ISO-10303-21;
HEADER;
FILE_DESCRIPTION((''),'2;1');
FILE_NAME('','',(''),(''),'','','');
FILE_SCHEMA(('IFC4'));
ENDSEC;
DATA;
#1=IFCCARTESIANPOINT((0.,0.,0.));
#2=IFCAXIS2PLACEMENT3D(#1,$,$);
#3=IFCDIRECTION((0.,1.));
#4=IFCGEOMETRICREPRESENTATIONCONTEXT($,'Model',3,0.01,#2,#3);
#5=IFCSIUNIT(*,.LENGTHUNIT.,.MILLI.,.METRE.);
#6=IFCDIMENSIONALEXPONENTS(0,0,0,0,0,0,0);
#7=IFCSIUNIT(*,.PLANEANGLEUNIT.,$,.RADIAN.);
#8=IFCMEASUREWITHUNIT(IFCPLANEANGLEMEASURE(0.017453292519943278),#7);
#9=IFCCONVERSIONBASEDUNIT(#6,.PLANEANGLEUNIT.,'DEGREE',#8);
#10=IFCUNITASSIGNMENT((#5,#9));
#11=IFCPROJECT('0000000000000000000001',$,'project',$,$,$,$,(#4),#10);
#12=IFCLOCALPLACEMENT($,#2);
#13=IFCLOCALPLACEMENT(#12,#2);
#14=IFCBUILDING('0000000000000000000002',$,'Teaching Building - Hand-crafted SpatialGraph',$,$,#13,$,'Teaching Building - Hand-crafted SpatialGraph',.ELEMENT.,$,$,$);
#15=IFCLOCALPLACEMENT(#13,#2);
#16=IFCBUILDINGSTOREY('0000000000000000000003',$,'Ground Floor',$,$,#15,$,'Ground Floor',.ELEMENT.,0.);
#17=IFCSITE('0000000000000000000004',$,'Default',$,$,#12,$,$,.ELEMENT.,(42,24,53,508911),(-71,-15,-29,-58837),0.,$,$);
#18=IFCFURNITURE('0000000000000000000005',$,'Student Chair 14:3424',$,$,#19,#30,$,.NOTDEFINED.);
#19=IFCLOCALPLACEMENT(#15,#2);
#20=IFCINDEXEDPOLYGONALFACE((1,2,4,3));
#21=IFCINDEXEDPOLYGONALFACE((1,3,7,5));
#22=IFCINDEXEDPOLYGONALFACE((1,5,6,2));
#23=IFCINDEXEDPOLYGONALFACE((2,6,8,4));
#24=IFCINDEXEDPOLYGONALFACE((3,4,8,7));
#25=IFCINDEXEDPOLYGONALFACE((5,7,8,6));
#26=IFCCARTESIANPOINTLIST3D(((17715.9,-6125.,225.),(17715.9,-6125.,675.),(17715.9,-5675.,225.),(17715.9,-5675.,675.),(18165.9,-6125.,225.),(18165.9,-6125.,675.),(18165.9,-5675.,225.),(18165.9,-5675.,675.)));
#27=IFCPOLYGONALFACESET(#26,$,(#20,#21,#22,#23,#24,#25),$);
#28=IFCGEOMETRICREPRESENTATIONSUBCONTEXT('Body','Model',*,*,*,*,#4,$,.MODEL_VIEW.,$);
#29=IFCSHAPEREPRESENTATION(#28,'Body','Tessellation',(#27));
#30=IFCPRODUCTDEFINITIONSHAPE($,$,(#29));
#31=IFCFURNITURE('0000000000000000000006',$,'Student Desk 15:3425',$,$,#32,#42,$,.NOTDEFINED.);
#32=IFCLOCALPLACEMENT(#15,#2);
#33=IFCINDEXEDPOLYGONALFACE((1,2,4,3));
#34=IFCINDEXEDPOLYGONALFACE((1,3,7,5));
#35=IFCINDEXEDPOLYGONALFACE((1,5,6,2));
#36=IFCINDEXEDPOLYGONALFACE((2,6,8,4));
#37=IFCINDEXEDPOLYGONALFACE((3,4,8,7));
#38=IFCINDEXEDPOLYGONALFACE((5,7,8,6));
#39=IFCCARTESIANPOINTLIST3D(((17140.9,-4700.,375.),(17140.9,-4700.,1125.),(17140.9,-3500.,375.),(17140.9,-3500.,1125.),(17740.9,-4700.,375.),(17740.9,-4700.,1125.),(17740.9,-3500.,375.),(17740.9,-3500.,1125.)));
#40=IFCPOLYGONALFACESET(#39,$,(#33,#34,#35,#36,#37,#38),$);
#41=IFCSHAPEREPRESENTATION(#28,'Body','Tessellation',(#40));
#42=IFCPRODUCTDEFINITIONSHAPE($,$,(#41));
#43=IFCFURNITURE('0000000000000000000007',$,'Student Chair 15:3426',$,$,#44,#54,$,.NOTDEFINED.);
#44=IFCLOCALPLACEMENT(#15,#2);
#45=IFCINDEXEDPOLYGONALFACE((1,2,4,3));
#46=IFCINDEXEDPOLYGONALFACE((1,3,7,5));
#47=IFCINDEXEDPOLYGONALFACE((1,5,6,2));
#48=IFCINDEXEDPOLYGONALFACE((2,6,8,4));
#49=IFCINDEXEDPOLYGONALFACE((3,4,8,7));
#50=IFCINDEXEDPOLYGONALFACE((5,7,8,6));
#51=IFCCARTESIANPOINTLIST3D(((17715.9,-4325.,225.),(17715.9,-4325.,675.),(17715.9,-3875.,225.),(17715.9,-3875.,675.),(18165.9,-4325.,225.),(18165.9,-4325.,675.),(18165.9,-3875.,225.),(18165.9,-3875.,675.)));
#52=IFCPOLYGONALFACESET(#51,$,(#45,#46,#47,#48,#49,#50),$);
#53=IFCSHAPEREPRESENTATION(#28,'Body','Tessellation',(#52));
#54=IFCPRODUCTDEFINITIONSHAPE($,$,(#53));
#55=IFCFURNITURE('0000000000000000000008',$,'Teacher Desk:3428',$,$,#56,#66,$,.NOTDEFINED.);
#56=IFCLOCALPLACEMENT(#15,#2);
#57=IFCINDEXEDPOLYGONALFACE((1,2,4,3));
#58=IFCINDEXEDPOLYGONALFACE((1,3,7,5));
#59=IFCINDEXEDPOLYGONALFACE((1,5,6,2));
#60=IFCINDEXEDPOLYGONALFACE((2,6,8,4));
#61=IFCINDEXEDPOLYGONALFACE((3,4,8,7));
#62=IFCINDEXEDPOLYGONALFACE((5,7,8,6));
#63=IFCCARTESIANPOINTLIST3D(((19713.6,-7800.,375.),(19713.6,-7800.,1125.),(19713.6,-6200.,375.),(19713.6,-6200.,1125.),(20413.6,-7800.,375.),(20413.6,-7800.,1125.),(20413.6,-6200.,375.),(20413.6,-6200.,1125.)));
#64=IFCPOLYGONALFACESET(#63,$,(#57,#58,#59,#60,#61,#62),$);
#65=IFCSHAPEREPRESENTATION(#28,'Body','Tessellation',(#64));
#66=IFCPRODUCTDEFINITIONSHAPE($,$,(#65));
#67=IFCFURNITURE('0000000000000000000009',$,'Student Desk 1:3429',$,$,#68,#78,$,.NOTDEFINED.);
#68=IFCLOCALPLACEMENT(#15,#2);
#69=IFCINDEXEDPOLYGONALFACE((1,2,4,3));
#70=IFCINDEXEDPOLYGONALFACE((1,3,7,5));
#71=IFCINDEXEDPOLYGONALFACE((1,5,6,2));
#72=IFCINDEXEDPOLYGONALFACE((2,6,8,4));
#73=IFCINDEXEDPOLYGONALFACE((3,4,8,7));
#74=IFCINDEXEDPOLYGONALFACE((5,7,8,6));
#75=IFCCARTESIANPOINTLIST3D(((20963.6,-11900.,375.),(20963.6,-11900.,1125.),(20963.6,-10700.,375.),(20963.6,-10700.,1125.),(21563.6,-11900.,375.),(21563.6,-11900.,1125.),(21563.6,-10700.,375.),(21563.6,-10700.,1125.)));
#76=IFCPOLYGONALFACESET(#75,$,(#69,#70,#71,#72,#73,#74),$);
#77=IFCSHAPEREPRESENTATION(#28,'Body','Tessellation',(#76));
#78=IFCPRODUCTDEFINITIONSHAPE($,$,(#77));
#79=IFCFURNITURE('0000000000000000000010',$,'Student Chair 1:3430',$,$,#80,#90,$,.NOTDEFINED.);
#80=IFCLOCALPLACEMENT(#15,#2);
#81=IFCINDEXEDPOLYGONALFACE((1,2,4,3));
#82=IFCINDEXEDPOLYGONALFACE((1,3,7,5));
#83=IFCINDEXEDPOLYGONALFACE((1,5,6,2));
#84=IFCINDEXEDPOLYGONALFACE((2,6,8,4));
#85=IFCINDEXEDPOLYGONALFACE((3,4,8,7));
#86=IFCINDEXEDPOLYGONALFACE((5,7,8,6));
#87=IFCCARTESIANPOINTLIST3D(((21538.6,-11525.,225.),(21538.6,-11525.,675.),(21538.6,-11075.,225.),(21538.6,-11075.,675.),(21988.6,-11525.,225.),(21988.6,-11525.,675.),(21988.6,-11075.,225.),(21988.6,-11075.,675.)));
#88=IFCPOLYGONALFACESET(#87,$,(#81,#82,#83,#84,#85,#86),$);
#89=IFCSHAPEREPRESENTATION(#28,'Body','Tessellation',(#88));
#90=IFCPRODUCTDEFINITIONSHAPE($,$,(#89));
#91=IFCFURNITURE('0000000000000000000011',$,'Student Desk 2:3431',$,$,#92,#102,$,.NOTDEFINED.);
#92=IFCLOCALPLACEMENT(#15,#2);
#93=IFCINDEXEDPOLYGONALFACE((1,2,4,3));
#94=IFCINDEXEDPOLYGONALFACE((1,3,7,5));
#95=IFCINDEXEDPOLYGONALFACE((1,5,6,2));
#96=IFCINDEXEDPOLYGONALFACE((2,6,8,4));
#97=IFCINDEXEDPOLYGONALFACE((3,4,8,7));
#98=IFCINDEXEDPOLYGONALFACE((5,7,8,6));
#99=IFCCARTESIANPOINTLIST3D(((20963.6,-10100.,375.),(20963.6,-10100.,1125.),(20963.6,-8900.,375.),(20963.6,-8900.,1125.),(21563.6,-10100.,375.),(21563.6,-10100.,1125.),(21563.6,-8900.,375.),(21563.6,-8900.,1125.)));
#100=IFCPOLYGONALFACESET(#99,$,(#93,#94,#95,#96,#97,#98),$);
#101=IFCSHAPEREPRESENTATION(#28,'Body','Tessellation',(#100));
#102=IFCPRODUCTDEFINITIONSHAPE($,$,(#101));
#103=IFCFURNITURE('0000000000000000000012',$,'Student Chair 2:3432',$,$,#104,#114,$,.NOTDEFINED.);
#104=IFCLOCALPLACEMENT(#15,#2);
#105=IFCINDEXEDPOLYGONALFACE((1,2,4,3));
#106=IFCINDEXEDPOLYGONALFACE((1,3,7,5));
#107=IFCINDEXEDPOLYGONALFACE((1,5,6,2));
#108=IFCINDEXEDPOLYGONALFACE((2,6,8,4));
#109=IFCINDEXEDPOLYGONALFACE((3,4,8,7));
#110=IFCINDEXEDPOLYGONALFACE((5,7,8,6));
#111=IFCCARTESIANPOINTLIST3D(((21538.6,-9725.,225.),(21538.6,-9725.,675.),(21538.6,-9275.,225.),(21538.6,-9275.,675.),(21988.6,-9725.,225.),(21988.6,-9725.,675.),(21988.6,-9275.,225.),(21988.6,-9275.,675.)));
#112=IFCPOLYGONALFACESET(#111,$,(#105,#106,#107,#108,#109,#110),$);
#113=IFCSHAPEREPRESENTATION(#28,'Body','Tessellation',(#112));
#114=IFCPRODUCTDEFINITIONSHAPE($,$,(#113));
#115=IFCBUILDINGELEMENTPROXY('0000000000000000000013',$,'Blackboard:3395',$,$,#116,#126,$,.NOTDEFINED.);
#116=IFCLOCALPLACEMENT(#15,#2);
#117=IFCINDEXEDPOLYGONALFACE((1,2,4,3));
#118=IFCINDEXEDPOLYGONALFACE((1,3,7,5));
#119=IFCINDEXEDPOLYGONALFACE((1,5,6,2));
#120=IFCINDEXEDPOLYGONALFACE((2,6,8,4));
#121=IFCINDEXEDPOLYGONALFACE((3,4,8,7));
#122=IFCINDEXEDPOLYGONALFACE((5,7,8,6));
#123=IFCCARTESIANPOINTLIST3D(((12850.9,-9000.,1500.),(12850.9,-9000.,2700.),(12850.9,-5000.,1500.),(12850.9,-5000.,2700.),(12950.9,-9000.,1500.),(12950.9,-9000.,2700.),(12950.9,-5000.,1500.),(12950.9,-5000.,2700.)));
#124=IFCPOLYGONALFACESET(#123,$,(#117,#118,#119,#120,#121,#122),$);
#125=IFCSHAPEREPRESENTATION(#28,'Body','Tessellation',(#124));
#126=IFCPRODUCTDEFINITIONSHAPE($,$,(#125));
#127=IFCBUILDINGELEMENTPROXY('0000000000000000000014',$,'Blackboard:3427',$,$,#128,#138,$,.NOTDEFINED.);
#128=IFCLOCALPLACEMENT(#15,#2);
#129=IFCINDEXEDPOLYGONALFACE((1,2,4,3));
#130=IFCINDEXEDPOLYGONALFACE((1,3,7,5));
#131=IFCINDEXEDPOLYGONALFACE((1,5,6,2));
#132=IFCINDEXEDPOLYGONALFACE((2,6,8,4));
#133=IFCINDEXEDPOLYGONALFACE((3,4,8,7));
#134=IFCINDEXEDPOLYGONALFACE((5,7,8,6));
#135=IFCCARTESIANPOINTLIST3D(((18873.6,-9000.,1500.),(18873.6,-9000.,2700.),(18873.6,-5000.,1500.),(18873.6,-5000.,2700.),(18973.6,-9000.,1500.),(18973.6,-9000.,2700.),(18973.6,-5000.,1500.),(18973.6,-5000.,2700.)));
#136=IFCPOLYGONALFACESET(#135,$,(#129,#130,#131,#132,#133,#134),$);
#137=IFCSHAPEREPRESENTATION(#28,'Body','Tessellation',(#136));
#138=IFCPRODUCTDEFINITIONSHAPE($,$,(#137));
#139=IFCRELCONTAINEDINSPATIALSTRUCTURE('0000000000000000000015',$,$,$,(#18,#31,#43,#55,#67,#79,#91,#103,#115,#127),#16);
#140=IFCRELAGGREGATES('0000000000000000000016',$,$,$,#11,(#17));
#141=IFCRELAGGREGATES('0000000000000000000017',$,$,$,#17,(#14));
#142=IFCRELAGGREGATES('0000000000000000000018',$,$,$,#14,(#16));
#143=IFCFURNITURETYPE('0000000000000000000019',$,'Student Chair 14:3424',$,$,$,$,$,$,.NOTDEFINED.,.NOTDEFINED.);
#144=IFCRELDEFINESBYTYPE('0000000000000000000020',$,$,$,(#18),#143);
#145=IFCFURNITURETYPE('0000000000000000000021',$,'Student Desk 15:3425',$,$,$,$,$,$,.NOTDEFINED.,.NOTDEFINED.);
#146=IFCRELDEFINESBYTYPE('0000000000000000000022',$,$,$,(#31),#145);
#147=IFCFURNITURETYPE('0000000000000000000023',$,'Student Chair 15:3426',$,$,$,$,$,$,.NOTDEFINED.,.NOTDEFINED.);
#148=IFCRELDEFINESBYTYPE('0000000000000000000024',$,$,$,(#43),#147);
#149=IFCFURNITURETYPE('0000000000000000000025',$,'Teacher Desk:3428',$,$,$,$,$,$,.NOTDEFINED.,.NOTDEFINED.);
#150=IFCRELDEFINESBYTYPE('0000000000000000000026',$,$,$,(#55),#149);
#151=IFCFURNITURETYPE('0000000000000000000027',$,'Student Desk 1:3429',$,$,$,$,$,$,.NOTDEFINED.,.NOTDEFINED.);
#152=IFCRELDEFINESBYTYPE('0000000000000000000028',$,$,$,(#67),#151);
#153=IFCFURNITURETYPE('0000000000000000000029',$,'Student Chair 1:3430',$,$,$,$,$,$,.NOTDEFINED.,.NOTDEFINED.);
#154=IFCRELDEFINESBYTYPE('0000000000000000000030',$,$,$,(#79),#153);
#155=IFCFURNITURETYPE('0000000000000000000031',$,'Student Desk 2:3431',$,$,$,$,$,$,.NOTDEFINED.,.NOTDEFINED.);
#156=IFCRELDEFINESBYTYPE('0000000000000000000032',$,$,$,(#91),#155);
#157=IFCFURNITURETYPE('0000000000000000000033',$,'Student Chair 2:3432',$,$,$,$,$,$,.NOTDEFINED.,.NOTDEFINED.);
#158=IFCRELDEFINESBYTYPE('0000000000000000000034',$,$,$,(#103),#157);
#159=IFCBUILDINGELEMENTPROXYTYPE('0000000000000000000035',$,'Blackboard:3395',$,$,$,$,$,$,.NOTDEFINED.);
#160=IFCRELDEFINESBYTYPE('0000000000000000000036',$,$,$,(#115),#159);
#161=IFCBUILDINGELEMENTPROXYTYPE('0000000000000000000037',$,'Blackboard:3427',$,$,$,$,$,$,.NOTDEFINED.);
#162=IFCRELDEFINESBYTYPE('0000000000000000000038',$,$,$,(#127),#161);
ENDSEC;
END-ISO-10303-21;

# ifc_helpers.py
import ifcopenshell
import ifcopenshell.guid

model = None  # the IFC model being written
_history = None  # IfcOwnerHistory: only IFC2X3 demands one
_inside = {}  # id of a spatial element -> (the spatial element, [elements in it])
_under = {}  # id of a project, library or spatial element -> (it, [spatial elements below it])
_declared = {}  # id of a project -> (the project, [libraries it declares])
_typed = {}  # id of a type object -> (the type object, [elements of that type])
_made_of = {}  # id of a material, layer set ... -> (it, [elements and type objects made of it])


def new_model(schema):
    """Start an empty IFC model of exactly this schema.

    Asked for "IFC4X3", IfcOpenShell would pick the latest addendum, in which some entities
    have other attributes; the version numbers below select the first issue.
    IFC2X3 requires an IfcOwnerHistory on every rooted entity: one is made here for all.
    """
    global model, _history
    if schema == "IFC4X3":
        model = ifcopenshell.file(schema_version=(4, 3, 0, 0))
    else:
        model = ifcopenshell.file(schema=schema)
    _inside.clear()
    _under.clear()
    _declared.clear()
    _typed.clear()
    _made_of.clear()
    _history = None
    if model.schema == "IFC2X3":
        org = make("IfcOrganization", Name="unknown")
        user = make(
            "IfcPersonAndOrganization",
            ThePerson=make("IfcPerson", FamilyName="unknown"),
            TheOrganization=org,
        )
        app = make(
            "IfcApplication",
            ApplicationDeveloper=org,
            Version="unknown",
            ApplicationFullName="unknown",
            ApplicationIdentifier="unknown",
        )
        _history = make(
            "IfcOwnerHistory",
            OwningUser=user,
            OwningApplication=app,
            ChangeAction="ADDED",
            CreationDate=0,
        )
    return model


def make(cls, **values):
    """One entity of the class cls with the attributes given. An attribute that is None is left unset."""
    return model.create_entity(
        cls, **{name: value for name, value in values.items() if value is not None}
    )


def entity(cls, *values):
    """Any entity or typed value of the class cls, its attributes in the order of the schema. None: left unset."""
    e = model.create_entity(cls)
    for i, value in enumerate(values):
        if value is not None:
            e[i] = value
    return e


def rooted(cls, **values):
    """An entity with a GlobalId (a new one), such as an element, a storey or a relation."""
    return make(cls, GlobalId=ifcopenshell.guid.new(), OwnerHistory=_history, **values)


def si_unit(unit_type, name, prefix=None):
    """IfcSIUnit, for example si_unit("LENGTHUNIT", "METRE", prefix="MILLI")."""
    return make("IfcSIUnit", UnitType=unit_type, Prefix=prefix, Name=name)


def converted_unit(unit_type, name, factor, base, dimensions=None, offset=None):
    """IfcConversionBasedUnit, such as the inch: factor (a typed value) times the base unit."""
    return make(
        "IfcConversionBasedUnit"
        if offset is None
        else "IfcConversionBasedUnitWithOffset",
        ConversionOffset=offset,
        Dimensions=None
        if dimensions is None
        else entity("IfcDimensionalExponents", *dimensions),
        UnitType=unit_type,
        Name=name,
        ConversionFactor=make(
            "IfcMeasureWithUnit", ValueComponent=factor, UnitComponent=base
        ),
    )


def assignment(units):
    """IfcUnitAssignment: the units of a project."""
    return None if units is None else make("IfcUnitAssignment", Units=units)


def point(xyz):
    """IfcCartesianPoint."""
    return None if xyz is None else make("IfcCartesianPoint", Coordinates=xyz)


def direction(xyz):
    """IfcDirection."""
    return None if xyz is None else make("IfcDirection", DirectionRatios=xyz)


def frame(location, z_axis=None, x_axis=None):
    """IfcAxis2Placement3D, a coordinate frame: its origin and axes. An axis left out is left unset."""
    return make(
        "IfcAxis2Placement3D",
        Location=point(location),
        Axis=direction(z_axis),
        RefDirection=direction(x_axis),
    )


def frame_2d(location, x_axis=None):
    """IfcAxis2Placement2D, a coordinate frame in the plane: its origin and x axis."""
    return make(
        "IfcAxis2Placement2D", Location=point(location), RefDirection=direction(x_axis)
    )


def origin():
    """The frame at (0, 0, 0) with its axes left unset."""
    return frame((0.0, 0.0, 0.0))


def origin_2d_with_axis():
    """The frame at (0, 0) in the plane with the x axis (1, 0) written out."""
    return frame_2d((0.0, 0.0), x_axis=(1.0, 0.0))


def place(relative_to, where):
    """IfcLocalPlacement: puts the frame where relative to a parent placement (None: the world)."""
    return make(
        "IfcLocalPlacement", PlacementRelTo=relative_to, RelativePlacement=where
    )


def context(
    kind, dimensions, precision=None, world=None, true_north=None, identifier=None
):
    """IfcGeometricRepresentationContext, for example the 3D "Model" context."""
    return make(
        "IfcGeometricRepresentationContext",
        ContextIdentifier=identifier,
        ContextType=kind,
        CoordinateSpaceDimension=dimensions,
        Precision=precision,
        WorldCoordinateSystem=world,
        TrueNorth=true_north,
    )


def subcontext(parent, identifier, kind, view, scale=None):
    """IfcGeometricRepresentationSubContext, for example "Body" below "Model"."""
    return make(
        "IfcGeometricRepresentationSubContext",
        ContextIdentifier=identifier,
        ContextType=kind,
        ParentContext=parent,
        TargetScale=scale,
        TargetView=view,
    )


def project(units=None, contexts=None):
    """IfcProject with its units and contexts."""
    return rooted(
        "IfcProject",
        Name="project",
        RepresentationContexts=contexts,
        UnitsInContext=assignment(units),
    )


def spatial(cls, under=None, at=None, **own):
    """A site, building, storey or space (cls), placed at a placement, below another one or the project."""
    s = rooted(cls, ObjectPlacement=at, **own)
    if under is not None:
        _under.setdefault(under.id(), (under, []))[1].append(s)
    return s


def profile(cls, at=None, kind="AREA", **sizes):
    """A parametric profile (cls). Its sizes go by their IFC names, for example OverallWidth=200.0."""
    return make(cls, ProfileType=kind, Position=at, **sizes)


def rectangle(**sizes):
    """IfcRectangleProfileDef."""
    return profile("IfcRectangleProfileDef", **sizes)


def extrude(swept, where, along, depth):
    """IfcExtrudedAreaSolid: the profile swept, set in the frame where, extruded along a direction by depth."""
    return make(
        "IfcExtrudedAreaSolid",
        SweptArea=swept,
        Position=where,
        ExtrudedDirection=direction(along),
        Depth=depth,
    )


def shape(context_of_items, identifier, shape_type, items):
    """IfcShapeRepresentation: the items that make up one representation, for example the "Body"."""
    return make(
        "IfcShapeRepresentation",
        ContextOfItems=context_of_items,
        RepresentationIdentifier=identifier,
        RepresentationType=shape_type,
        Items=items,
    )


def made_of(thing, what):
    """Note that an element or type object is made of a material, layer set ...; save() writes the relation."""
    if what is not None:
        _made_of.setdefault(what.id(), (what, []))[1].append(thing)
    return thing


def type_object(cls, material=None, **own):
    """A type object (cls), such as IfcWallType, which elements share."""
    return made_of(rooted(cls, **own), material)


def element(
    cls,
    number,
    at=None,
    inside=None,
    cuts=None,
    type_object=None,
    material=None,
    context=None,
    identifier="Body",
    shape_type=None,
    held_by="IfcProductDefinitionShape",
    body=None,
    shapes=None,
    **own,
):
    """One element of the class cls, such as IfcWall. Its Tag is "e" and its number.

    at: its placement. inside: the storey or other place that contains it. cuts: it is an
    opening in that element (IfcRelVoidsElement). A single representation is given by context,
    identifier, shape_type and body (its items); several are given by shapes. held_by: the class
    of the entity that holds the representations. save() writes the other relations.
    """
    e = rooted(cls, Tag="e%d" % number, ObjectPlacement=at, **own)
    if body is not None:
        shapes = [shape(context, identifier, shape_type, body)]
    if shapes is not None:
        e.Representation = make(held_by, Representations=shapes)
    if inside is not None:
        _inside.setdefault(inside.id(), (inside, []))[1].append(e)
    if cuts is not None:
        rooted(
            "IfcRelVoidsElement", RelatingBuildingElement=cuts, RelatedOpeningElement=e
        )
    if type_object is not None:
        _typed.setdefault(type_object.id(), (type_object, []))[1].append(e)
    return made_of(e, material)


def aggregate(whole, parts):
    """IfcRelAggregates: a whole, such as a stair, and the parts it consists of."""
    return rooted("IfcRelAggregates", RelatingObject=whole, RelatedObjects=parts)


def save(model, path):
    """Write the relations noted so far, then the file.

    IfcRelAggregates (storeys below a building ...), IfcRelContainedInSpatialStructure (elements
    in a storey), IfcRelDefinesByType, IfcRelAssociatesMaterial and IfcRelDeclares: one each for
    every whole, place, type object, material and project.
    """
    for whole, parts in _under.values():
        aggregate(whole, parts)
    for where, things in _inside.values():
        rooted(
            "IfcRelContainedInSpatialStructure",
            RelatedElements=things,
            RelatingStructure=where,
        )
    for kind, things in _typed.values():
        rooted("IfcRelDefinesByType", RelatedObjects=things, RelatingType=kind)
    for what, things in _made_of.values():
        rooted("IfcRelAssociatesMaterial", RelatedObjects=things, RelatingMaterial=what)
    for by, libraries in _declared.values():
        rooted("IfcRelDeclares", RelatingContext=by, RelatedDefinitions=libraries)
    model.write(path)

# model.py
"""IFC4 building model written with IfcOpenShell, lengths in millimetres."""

from ifc_helpers import new_model, entity, si_unit, converted_unit, direction, frame, origin, origin_2d_with_axis, place, context, subcontext, project, spatial, rectangle, extrude, type_object, element, save


model = new_model("IFC4")

# Units and contexts
model_context = context("Model", 3, precision=0.01, world=origin(), true_north=direction((0.0, 1.0)))
body_context = subcontext(model_context, "Body", "Model", "MODEL_VIEW")
ifc_project = project(units=[si_unit("LENGTHUNIT", "METRE", prefix="MILLI"), converted_unit("PLANEANGLEUNIT", "DEGREE", entity("IfcPlaneAngleMeasure", 0.017453292519943278), si_unit("PLANEANGLEUNIT", "RADIAN"), dimensions=[0, 0, 0, 0, 0, 0, 0])], contexts=[model_context])

# Site, building, storey
site_placement = place(None, origin())
site = spatial("IfcSite", under=ifc_project, at=site_placement, Name="Default", CompositionType="ELEMENT", RefLatitude=(42, 24, 53, 508911), RefLongitude=(-71, -15, -29, -58837), RefElevation=0.0)
building_placement = place(site_placement, origin())
building = spatial("IfcBuilding", under=site, at=building_placement, Name="Teaching Building - Hand-crafted SpatialGraph", LongName="Teaching Building - Hand-crafted SpatialGraph", CompositionType="ELEMENT")
storey_placement = place(building_placement, origin())
storey = spatial("IfcBuildingStorey", under=building, at=storey_placement, Name="Ground Floor", LongName="Ground Floor", CompositionType="ELEMENT", Elevation=0.0)

# Furniture
furniture_type_1 = type_object("IfcFurnitureType", Name="Student Chair 14:3424", PredefinedType="NOTDEFINED")
furniture_1_placement = place(storey_placement, origin())
element("IfcFurniture", 1, at=furniture_1_placement, inside=storey, type_object=furniture_type_1, Name="Student Chair 14:3424", PredefinedType="NOTDEFINED", context=body_context, shape_type="SweptSolid", body=[
    extrude(rectangle(XDim=450.0, YDim=450.0, at=origin_2d_with_axis()), frame((17940.9, -5900.0, 225.0)), (0.0, 0.0, 1.0), 450.0),
])
furniture_type_2 = type_object("IfcFurnitureType", Name="Student Desk 15:3425", PredefinedType="NOTDEFINED")
furniture_2_placement = place(storey_placement, origin())
element("IfcFurniture", 2, at=furniture_2_placement, inside=storey, type_object=furniture_type_2, Name="Student Desk 15:3425", PredefinedType="NOTDEFINED", context=body_context, shape_type="SweptSolid", body=[
    extrude(rectangle(XDim=1200.0, YDim=600.0, at=origin_2d_with_axis()), frame((17440.9, -4100.0, 375.0), z_axis=(0.0, 0.0, 1.0), x_axis=(0.0, 1.0, 0.0)), (0.0, 0.0, 1.0), 750.0),
])
furniture_type_3 = type_object("IfcFurnitureType", Name="Student Chair 15:3426", PredefinedType="NOTDEFINED")
furniture_3_placement = place(storey_placement, origin())
element("IfcFurniture", 3, at=furniture_3_placement, inside=storey, type_object=furniture_type_3, Name="Student Chair 15:3426", PredefinedType="NOTDEFINED", context=body_context, shape_type="SweptSolid", body=[
    extrude(rectangle(XDim=450.0, YDim=450.0, at=origin_2d_with_axis()), frame((17940.9, -4100.0, 225.0)), (0.0, 0.0, 1.0), 450.0),
])
furniture_type_4 = type_object("IfcFurnitureType", Name="Teacher Desk:3428", PredefinedType="NOTDEFINED")
furniture_4_placement = place(storey_placement, origin())
element("IfcFurniture", 4, at=furniture_4_placement, inside=storey, type_object=furniture_type_4, Name="Teacher Desk:3428", PredefinedType="NOTDEFINED", context=body_context, shape_type="SweptSolid", body=[
    extrude(rectangle(XDim=1600.0, YDim=700.0, at=origin_2d_with_axis()), frame((20063.6, -7000.0, 375.0), z_axis=(0.0, 0.0, 1.0), x_axis=(0.0, 1.0, 0.0)), (0.0, 0.0, 1.0), 750.0),
])
furniture_type_5 = type_object("IfcFurnitureType", Name="Student Desk 1:3429", PredefinedType="NOTDEFINED")
furniture_5_placement = place(storey_placement, origin())
element("IfcFurniture", 5, at=furniture_5_placement, inside=storey, type_object=furniture_type_5, Name="Student Desk 1:3429", PredefinedType="NOTDEFINED", context=body_context, shape_type="SweptSolid", body=[
    extrude(rectangle(XDim=1200.0, YDim=600.0, at=origin_2d_with_axis()), frame((21263.6, -11300.0, 375.0), z_axis=(0.0, 0.0, 1.0), x_axis=(0.0, 1.0, 0.0)), (0.0, 0.0, 1.0), 750.0),
])
furniture_type_6 = type_object("IfcFurnitureType", Name="Student Chair 1:3430", PredefinedType="NOTDEFINED")
furniture_6_placement = place(storey_placement, origin())
element("IfcFurniture", 6, at=furniture_6_placement, inside=storey, type_object=furniture_type_6, Name="Student Chair 1:3430", PredefinedType="NOTDEFINED", context=body_context, shape_type="SweptSolid", body=[
    extrude(rectangle(XDim=450.0, YDim=450.0, at=origin_2d_with_axis()), frame((21763.6, -11300.0, 225.0)), (0.0, 0.0, 1.0), 450.0),
])
furniture_type_7 = type_object("IfcFurnitureType", Name="Student Desk 2:3431", PredefinedType="NOTDEFINED")
furniture_7_placement = place(storey_placement, origin())
element("IfcFurniture", 7, at=furniture_7_placement, inside=storey, type_object=furniture_type_7, Name="Student Desk 2:3431", PredefinedType="NOTDEFINED", context=body_context, shape_type="SweptSolid", body=[
    extrude(rectangle(XDim=1200.0, YDim=600.0, at=origin_2d_with_axis()), frame((21263.6, -9500.0, 375.0), z_axis=(0.0, 0.0, 1.0), x_axis=(0.0, 1.0, 0.0)), (0.0, 0.0, 1.0), 750.0),
])
furniture_type_8 = type_object("IfcFurnitureType", Name="Student Chair 2:3432", PredefinedType="NOTDEFINED")
furniture_8_placement = place(storey_placement, origin())
element("IfcFurniture", 8, at=furniture_8_placement, inside=storey, type_object=furniture_type_8, Name="Student Chair 2:3432", PredefinedType="NOTDEFINED", context=body_context, shape_type="SweptSolid", body=[
    extrude(rectangle(XDim=450.0, YDim=450.0, at=origin_2d_with_axis()), frame((21763.6, -9500.0, 225.0)), (0.0, 0.0, 1.0), 450.0),
])

# Building element proxies
building_element_proxy_type_1 = type_object("IfcBuildingElementProxyType", Name="Blackboard:3395", PredefinedType="NOTDEFINED")
proxy_1_placement = place(storey_placement, origin())
element("IfcBuildingElementProxy", 9, at=proxy_1_placement, inside=storey, type_object=building_element_proxy_type_1, Name="Blackboard:3395", PredefinedType="NOTDEFINED", context=body_context, shape_type="SweptSolid", body=[
    extrude(rectangle(XDim=100.0, YDim=4000.0, at=origin_2d_with_axis()), frame((12900.9, -7000.0, 1500.0)), (0.0, 0.0, 1.0), 1200.0),
])
building_element_proxy_type_2 = type_object("IfcBuildingElementProxyType", Name="Blackboard:3427", PredefinedType="NOTDEFINED")
proxy_2_placement = place(storey_placement, origin())
element("IfcBuildingElementProxy", 10, at=proxy_2_placement, inside=storey, type_object=building_element_proxy_type_2, Name="Blackboard:3427", PredefinedType="NOTDEFINED", context=body_context, shape_type="SweptSolid", body=[
    extrude(rectangle(XDim=100.0, YDim=4000.0, at=origin_2d_with_axis()), frame((18923.6, -7000.0, 1500.0)), (0.0, 0.0, 1.0), 1200.0),
])

save(model, "model.ifc")
